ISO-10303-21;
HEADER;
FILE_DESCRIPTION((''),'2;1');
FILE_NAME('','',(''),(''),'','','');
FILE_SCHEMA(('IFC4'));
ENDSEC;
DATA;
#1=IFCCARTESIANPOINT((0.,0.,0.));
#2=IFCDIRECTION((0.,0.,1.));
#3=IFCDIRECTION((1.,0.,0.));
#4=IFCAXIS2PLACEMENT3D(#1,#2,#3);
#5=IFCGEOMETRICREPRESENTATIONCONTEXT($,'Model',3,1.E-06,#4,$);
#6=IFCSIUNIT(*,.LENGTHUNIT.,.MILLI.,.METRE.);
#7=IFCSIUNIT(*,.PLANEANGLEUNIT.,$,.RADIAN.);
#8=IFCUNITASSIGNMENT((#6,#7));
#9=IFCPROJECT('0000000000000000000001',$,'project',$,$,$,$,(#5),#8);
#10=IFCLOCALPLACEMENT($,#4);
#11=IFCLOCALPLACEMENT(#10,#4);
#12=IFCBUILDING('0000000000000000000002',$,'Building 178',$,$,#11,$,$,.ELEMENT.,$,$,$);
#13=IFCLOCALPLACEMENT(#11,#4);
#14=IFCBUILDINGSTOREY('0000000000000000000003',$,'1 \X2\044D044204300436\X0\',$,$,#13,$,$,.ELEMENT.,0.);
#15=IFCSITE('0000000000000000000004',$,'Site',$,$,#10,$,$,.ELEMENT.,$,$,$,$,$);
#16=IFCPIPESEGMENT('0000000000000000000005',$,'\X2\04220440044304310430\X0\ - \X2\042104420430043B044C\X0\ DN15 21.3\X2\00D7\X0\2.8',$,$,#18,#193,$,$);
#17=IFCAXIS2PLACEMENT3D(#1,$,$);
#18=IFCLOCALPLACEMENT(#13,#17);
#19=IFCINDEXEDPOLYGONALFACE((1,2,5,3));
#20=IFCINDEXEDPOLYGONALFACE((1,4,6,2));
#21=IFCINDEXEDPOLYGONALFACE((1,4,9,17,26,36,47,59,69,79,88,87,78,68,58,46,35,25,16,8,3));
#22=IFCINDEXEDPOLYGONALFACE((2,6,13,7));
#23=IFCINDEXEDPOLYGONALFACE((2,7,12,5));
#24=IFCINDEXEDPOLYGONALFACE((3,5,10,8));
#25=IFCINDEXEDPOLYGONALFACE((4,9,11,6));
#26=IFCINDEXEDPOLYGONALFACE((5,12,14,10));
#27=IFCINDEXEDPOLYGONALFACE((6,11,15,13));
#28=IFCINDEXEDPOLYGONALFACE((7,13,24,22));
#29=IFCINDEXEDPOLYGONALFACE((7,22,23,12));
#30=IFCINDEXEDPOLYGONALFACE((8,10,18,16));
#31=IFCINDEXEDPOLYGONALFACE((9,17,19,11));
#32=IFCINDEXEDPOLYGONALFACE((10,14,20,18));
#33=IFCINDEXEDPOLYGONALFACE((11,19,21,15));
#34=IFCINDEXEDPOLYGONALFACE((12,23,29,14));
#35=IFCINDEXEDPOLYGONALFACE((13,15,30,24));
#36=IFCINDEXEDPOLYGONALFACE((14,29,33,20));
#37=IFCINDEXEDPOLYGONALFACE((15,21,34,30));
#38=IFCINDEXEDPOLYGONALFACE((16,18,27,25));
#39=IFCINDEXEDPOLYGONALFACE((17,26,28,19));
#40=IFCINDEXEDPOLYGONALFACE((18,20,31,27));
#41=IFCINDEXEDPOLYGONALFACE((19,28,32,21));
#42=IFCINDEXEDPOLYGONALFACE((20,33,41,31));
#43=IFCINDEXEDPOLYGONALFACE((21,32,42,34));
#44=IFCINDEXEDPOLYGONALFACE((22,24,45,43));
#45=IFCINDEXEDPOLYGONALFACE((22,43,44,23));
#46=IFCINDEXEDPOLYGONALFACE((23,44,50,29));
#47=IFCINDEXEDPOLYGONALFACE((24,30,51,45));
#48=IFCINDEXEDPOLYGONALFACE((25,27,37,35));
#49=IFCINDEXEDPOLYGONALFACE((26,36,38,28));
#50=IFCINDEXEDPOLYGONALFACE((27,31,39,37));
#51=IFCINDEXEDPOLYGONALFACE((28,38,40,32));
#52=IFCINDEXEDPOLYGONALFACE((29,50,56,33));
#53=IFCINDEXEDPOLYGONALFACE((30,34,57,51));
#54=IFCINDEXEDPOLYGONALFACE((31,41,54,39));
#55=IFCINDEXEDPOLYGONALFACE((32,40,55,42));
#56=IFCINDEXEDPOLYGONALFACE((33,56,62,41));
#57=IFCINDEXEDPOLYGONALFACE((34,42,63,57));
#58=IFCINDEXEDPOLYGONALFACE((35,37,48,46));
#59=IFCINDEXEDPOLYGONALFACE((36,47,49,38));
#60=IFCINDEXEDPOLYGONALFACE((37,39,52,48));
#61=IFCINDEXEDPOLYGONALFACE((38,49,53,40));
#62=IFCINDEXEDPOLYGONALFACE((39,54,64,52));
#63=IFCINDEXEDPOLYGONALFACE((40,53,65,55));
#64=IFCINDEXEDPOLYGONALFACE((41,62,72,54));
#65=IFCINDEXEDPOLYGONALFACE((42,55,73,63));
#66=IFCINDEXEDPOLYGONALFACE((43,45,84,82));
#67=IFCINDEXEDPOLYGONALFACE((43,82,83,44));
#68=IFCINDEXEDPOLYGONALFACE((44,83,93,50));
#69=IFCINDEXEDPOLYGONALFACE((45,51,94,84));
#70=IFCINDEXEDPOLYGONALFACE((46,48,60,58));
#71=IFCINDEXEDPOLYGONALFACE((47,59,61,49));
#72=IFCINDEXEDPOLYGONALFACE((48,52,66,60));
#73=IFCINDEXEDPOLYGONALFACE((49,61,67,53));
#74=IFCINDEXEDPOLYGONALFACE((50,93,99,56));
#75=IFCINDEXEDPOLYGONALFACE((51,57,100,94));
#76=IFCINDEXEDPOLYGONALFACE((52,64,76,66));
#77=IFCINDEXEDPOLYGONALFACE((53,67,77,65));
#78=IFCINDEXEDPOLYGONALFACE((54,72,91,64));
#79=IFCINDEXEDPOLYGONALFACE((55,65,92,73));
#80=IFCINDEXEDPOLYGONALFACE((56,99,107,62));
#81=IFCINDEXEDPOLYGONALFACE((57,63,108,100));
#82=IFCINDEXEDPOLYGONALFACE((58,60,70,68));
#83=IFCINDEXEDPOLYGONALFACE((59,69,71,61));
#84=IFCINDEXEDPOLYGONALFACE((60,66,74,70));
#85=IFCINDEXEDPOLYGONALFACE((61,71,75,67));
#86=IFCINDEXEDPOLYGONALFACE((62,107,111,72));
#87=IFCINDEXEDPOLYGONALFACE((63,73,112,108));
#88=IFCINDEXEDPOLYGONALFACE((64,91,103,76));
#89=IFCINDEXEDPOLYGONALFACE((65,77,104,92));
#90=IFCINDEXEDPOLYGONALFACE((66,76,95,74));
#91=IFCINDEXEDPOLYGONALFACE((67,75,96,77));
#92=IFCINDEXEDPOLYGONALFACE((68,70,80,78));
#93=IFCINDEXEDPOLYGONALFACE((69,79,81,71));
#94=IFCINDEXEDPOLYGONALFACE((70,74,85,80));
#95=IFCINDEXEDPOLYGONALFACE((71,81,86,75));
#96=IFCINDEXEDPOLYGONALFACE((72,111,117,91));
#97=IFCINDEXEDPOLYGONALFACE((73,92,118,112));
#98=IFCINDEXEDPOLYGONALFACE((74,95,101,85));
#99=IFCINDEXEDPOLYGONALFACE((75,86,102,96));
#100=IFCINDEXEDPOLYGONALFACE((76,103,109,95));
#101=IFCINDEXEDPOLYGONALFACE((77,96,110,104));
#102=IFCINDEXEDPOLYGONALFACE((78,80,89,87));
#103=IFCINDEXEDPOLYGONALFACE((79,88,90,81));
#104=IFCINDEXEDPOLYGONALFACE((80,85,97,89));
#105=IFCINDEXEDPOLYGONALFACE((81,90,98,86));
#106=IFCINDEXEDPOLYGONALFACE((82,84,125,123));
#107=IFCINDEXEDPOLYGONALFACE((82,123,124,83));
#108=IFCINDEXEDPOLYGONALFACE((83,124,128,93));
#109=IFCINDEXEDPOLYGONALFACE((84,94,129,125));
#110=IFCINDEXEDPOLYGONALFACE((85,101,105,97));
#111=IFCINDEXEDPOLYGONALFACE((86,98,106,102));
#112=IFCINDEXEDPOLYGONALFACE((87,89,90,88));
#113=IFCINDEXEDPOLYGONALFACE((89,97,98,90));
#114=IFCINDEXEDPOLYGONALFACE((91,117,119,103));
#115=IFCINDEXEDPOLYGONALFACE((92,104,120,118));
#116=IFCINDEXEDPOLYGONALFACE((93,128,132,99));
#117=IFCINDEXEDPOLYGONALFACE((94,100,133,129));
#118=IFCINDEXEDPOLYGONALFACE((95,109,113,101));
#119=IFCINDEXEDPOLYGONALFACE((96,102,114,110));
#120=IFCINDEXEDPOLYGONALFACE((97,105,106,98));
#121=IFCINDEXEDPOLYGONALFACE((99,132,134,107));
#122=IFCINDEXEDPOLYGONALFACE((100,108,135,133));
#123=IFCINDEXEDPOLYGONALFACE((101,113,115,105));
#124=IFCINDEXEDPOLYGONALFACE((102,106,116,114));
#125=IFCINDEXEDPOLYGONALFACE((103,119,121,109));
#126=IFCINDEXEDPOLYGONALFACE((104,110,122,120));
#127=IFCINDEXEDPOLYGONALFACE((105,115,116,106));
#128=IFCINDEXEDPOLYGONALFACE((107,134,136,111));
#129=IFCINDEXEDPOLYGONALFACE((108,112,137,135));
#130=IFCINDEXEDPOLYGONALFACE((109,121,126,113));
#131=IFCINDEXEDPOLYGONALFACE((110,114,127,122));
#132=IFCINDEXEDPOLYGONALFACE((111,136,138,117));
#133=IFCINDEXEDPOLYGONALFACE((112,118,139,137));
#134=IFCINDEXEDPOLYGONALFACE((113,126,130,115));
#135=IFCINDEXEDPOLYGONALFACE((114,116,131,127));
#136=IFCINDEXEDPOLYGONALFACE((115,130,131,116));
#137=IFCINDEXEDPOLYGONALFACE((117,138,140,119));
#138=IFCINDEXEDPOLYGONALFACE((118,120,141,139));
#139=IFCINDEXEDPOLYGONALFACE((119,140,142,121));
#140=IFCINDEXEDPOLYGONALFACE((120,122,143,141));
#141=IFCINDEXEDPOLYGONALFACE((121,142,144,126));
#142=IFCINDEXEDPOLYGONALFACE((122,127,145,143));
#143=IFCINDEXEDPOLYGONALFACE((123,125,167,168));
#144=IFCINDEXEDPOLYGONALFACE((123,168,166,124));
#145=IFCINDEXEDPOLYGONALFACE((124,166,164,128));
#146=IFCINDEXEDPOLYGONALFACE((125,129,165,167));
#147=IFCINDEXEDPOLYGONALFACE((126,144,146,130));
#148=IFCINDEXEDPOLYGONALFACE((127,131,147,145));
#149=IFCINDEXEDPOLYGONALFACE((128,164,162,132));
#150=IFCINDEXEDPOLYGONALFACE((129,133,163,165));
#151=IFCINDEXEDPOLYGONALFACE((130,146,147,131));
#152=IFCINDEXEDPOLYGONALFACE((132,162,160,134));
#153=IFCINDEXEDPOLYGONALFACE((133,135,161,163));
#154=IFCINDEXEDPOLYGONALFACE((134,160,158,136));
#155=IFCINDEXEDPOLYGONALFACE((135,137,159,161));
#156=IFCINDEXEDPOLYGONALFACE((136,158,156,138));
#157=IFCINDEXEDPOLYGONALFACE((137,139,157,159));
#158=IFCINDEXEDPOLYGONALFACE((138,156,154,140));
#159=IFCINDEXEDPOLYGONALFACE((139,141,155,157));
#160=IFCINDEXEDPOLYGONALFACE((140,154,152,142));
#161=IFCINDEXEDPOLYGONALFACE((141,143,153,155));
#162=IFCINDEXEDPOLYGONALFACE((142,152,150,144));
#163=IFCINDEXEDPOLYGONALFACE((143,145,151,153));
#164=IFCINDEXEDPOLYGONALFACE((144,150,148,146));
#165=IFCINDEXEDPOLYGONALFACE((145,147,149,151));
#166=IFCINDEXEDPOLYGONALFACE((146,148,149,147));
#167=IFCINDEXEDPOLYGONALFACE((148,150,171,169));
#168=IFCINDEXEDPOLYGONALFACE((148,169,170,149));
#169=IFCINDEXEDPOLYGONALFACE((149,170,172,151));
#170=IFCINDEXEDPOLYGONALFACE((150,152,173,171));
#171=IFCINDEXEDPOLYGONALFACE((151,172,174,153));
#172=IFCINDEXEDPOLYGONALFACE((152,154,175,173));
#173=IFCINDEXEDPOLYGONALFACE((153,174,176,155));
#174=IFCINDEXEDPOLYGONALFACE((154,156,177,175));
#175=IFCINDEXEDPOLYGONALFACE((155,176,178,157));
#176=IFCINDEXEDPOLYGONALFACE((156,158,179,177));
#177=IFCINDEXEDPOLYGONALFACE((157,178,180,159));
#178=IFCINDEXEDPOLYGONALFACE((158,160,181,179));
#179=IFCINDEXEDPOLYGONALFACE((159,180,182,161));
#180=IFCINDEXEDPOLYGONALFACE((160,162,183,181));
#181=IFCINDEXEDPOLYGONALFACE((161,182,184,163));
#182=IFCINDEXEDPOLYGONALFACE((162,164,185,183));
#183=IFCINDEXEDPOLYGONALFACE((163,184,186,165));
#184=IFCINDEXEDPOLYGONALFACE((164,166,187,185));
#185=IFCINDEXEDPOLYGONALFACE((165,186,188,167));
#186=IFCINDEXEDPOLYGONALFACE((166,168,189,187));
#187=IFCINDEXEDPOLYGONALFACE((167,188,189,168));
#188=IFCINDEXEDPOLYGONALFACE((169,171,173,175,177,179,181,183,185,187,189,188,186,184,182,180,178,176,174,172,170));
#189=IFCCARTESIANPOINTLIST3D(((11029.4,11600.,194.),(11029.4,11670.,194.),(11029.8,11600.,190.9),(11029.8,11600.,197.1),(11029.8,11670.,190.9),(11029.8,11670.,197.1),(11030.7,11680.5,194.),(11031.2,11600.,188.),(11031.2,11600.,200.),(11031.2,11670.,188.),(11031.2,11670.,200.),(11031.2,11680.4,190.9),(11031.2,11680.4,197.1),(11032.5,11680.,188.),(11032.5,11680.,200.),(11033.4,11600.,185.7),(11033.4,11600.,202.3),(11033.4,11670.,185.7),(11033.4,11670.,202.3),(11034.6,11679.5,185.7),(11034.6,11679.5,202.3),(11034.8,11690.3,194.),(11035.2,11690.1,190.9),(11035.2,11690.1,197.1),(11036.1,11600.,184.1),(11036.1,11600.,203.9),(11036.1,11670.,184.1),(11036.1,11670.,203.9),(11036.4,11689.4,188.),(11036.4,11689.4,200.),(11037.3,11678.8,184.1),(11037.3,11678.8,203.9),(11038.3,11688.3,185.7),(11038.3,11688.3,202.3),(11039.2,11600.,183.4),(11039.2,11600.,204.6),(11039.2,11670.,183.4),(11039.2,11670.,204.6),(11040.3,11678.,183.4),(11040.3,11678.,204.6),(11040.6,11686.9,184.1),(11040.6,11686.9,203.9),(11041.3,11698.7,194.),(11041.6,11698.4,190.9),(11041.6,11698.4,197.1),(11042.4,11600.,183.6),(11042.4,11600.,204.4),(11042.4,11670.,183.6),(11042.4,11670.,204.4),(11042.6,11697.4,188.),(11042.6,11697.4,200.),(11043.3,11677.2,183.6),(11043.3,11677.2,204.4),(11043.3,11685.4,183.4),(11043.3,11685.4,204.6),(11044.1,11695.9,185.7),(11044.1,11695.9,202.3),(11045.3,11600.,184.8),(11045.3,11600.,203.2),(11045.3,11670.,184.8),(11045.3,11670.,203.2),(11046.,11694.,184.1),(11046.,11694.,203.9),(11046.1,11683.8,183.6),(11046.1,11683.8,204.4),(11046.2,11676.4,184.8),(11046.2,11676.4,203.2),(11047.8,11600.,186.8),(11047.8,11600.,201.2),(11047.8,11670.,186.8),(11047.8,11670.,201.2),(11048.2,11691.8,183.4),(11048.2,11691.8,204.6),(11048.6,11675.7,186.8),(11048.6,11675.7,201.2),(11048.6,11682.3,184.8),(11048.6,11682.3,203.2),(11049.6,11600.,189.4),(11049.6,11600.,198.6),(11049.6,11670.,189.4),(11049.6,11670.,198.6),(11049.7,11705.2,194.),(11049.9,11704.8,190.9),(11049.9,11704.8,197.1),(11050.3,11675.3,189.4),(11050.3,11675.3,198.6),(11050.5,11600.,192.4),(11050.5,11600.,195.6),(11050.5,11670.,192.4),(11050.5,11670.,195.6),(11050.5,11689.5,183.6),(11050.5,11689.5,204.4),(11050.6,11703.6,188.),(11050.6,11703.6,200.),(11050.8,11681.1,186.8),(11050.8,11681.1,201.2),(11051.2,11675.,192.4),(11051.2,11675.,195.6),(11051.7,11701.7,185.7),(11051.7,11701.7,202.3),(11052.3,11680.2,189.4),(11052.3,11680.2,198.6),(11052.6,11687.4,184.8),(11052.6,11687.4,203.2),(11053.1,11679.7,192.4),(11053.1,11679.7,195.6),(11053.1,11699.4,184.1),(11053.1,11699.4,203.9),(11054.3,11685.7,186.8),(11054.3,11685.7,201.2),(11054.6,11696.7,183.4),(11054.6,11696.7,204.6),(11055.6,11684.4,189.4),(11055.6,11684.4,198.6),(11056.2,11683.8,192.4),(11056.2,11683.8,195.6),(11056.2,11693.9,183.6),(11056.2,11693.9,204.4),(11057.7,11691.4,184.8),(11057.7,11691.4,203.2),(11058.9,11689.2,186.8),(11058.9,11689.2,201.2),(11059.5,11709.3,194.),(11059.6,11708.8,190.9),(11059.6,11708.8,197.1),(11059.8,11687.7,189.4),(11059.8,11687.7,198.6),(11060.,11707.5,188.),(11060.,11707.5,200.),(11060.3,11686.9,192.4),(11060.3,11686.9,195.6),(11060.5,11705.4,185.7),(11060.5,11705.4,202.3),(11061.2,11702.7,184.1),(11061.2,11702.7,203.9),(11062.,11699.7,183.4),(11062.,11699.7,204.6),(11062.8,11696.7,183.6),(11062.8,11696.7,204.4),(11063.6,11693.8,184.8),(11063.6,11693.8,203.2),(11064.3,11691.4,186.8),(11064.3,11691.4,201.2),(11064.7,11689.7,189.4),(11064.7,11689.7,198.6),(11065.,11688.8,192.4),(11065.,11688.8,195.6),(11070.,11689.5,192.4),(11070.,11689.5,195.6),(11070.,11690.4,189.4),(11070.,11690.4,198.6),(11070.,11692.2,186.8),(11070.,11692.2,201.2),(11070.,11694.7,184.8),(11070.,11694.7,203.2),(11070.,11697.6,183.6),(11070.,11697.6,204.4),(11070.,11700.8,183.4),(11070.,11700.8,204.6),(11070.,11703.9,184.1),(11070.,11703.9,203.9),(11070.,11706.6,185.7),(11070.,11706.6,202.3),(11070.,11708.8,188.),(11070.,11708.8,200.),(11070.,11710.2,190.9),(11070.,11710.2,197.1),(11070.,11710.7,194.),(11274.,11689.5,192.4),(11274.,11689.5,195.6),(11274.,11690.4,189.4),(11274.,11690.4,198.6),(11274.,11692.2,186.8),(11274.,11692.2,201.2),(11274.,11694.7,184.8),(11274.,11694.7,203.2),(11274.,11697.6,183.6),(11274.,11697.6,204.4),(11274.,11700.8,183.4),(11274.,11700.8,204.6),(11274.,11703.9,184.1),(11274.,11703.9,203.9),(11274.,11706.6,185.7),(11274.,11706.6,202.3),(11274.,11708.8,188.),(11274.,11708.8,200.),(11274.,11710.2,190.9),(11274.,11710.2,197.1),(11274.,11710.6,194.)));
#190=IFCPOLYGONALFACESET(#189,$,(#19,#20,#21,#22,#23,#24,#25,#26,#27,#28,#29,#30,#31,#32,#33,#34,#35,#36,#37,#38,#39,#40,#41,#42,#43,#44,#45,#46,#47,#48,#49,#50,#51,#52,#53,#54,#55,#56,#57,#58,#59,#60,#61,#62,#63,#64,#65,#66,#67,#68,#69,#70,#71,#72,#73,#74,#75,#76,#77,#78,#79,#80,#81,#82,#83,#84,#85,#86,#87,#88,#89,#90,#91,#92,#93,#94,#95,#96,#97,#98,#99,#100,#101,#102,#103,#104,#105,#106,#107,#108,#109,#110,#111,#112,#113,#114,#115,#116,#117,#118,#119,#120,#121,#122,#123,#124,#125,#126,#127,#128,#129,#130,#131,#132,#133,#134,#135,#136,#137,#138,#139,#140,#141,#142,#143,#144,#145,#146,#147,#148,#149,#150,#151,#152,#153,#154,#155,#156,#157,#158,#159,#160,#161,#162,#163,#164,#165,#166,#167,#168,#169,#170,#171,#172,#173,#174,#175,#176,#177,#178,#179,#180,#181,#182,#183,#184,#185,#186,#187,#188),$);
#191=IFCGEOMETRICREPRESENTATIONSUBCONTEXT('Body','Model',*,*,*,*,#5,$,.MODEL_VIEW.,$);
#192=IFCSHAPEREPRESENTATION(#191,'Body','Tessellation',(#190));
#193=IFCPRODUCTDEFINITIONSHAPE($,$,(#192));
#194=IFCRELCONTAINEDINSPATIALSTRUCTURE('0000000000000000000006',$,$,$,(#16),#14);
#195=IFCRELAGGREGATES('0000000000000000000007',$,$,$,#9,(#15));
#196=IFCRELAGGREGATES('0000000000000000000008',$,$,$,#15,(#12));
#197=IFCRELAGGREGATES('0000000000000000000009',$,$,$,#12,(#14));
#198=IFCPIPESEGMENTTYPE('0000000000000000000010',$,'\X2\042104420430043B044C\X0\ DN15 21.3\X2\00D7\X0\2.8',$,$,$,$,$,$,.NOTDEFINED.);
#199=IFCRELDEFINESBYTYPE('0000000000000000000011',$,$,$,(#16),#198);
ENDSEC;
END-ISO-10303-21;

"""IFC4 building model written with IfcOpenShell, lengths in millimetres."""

from ifc_helpers import new_model, entity, si_unit, frame, origin_with_axes, place, context, subcontext, project, spatial, source, transform, mapped, type_object, element, save


model = new_model("IFC4")

# Units and contexts
model_context = context("Model", 3, precision=1e-06, world=origin_with_axes())
body_context = subcontext(model_context, "Body", "Model", "MODEL_VIEW")
ifc_project = project(units=[si_unit("LENGTHUNIT", "METRE", prefix="MILLI"), si_unit("PLANEANGLEUNIT", "RADIAN")], contexts=[model_context])

# Site, building, storey
site_placement = place(None, origin_with_axes())
site = spatial("IfcSite", under=ifc_project, at=site_placement, Name="Site", CompositionType="ELEMENT")
building_placement = place(site_placement, origin_with_axes())
building = spatial("IfcBuilding", under=site, at=building_placement, Name="Building 178", CompositionType="ELEMENT")
storey_placement = place(building_placement, origin_with_axes())
storey = spatial("IfcBuildingStorey", under=building, at=storey_placement, Name="1 этаж", CompositionType="ELEMENT", Elevation=0.0)

# Pipe segment
pipe_segment_type = type_object("IfcPipeSegmentType", Name="Сталь DN15 21.3×2.8", PredefinedType="NOTDEFINED")
shared_shape_1 = source(origin_with_axes(), body_context, "Body", "AdvancedSweptSolid", [
    entity("IfcSweptDiskSolid", entity("IfcIndexedPolyCurve", entity("IfcCartesianPointList3D", [[0.0, 0.0, 0.0], [0.0, 0.0, -70.0], [8.8, 0.0, -91.2], [30.0, 0.0, -100.0], [234.0, 0.0, -100.0]]), [entity("IfcLineIndex", [1, 2]), entity("IfcArcIndex", [2, 3, 4]), entity("IfcLineIndex", [4, 5])]), 10.7),
])
for number, where, z_axis, x_axis, name in (
    (1, (11040.0, 11600.0, 194.0), (0.0, -1.0, 0.0), (1.0, 0.0, 0.0), "Труба - Сталь DN15 21.3×2.8"),
):
    element("IfcPipeSegment", number, at=place(storey_placement, frame(where, z_axis=z_axis, x_axis=x_axis)), inside=storey, type_object=pipe_segment_type, Name=name, context=body_context, shape_type="MappedRepresentation", body=[
        mapped(shared_shape_1, transform((0.0, 0.0, 0.0), x_axis=(1.0, 0.0, 0.0), y_axis=(0.0, 1.0, 0.0), z_axis=(0.0, 0.0, 1.0), scale=1.0)),
    ])

save(model, "model.ifc")
